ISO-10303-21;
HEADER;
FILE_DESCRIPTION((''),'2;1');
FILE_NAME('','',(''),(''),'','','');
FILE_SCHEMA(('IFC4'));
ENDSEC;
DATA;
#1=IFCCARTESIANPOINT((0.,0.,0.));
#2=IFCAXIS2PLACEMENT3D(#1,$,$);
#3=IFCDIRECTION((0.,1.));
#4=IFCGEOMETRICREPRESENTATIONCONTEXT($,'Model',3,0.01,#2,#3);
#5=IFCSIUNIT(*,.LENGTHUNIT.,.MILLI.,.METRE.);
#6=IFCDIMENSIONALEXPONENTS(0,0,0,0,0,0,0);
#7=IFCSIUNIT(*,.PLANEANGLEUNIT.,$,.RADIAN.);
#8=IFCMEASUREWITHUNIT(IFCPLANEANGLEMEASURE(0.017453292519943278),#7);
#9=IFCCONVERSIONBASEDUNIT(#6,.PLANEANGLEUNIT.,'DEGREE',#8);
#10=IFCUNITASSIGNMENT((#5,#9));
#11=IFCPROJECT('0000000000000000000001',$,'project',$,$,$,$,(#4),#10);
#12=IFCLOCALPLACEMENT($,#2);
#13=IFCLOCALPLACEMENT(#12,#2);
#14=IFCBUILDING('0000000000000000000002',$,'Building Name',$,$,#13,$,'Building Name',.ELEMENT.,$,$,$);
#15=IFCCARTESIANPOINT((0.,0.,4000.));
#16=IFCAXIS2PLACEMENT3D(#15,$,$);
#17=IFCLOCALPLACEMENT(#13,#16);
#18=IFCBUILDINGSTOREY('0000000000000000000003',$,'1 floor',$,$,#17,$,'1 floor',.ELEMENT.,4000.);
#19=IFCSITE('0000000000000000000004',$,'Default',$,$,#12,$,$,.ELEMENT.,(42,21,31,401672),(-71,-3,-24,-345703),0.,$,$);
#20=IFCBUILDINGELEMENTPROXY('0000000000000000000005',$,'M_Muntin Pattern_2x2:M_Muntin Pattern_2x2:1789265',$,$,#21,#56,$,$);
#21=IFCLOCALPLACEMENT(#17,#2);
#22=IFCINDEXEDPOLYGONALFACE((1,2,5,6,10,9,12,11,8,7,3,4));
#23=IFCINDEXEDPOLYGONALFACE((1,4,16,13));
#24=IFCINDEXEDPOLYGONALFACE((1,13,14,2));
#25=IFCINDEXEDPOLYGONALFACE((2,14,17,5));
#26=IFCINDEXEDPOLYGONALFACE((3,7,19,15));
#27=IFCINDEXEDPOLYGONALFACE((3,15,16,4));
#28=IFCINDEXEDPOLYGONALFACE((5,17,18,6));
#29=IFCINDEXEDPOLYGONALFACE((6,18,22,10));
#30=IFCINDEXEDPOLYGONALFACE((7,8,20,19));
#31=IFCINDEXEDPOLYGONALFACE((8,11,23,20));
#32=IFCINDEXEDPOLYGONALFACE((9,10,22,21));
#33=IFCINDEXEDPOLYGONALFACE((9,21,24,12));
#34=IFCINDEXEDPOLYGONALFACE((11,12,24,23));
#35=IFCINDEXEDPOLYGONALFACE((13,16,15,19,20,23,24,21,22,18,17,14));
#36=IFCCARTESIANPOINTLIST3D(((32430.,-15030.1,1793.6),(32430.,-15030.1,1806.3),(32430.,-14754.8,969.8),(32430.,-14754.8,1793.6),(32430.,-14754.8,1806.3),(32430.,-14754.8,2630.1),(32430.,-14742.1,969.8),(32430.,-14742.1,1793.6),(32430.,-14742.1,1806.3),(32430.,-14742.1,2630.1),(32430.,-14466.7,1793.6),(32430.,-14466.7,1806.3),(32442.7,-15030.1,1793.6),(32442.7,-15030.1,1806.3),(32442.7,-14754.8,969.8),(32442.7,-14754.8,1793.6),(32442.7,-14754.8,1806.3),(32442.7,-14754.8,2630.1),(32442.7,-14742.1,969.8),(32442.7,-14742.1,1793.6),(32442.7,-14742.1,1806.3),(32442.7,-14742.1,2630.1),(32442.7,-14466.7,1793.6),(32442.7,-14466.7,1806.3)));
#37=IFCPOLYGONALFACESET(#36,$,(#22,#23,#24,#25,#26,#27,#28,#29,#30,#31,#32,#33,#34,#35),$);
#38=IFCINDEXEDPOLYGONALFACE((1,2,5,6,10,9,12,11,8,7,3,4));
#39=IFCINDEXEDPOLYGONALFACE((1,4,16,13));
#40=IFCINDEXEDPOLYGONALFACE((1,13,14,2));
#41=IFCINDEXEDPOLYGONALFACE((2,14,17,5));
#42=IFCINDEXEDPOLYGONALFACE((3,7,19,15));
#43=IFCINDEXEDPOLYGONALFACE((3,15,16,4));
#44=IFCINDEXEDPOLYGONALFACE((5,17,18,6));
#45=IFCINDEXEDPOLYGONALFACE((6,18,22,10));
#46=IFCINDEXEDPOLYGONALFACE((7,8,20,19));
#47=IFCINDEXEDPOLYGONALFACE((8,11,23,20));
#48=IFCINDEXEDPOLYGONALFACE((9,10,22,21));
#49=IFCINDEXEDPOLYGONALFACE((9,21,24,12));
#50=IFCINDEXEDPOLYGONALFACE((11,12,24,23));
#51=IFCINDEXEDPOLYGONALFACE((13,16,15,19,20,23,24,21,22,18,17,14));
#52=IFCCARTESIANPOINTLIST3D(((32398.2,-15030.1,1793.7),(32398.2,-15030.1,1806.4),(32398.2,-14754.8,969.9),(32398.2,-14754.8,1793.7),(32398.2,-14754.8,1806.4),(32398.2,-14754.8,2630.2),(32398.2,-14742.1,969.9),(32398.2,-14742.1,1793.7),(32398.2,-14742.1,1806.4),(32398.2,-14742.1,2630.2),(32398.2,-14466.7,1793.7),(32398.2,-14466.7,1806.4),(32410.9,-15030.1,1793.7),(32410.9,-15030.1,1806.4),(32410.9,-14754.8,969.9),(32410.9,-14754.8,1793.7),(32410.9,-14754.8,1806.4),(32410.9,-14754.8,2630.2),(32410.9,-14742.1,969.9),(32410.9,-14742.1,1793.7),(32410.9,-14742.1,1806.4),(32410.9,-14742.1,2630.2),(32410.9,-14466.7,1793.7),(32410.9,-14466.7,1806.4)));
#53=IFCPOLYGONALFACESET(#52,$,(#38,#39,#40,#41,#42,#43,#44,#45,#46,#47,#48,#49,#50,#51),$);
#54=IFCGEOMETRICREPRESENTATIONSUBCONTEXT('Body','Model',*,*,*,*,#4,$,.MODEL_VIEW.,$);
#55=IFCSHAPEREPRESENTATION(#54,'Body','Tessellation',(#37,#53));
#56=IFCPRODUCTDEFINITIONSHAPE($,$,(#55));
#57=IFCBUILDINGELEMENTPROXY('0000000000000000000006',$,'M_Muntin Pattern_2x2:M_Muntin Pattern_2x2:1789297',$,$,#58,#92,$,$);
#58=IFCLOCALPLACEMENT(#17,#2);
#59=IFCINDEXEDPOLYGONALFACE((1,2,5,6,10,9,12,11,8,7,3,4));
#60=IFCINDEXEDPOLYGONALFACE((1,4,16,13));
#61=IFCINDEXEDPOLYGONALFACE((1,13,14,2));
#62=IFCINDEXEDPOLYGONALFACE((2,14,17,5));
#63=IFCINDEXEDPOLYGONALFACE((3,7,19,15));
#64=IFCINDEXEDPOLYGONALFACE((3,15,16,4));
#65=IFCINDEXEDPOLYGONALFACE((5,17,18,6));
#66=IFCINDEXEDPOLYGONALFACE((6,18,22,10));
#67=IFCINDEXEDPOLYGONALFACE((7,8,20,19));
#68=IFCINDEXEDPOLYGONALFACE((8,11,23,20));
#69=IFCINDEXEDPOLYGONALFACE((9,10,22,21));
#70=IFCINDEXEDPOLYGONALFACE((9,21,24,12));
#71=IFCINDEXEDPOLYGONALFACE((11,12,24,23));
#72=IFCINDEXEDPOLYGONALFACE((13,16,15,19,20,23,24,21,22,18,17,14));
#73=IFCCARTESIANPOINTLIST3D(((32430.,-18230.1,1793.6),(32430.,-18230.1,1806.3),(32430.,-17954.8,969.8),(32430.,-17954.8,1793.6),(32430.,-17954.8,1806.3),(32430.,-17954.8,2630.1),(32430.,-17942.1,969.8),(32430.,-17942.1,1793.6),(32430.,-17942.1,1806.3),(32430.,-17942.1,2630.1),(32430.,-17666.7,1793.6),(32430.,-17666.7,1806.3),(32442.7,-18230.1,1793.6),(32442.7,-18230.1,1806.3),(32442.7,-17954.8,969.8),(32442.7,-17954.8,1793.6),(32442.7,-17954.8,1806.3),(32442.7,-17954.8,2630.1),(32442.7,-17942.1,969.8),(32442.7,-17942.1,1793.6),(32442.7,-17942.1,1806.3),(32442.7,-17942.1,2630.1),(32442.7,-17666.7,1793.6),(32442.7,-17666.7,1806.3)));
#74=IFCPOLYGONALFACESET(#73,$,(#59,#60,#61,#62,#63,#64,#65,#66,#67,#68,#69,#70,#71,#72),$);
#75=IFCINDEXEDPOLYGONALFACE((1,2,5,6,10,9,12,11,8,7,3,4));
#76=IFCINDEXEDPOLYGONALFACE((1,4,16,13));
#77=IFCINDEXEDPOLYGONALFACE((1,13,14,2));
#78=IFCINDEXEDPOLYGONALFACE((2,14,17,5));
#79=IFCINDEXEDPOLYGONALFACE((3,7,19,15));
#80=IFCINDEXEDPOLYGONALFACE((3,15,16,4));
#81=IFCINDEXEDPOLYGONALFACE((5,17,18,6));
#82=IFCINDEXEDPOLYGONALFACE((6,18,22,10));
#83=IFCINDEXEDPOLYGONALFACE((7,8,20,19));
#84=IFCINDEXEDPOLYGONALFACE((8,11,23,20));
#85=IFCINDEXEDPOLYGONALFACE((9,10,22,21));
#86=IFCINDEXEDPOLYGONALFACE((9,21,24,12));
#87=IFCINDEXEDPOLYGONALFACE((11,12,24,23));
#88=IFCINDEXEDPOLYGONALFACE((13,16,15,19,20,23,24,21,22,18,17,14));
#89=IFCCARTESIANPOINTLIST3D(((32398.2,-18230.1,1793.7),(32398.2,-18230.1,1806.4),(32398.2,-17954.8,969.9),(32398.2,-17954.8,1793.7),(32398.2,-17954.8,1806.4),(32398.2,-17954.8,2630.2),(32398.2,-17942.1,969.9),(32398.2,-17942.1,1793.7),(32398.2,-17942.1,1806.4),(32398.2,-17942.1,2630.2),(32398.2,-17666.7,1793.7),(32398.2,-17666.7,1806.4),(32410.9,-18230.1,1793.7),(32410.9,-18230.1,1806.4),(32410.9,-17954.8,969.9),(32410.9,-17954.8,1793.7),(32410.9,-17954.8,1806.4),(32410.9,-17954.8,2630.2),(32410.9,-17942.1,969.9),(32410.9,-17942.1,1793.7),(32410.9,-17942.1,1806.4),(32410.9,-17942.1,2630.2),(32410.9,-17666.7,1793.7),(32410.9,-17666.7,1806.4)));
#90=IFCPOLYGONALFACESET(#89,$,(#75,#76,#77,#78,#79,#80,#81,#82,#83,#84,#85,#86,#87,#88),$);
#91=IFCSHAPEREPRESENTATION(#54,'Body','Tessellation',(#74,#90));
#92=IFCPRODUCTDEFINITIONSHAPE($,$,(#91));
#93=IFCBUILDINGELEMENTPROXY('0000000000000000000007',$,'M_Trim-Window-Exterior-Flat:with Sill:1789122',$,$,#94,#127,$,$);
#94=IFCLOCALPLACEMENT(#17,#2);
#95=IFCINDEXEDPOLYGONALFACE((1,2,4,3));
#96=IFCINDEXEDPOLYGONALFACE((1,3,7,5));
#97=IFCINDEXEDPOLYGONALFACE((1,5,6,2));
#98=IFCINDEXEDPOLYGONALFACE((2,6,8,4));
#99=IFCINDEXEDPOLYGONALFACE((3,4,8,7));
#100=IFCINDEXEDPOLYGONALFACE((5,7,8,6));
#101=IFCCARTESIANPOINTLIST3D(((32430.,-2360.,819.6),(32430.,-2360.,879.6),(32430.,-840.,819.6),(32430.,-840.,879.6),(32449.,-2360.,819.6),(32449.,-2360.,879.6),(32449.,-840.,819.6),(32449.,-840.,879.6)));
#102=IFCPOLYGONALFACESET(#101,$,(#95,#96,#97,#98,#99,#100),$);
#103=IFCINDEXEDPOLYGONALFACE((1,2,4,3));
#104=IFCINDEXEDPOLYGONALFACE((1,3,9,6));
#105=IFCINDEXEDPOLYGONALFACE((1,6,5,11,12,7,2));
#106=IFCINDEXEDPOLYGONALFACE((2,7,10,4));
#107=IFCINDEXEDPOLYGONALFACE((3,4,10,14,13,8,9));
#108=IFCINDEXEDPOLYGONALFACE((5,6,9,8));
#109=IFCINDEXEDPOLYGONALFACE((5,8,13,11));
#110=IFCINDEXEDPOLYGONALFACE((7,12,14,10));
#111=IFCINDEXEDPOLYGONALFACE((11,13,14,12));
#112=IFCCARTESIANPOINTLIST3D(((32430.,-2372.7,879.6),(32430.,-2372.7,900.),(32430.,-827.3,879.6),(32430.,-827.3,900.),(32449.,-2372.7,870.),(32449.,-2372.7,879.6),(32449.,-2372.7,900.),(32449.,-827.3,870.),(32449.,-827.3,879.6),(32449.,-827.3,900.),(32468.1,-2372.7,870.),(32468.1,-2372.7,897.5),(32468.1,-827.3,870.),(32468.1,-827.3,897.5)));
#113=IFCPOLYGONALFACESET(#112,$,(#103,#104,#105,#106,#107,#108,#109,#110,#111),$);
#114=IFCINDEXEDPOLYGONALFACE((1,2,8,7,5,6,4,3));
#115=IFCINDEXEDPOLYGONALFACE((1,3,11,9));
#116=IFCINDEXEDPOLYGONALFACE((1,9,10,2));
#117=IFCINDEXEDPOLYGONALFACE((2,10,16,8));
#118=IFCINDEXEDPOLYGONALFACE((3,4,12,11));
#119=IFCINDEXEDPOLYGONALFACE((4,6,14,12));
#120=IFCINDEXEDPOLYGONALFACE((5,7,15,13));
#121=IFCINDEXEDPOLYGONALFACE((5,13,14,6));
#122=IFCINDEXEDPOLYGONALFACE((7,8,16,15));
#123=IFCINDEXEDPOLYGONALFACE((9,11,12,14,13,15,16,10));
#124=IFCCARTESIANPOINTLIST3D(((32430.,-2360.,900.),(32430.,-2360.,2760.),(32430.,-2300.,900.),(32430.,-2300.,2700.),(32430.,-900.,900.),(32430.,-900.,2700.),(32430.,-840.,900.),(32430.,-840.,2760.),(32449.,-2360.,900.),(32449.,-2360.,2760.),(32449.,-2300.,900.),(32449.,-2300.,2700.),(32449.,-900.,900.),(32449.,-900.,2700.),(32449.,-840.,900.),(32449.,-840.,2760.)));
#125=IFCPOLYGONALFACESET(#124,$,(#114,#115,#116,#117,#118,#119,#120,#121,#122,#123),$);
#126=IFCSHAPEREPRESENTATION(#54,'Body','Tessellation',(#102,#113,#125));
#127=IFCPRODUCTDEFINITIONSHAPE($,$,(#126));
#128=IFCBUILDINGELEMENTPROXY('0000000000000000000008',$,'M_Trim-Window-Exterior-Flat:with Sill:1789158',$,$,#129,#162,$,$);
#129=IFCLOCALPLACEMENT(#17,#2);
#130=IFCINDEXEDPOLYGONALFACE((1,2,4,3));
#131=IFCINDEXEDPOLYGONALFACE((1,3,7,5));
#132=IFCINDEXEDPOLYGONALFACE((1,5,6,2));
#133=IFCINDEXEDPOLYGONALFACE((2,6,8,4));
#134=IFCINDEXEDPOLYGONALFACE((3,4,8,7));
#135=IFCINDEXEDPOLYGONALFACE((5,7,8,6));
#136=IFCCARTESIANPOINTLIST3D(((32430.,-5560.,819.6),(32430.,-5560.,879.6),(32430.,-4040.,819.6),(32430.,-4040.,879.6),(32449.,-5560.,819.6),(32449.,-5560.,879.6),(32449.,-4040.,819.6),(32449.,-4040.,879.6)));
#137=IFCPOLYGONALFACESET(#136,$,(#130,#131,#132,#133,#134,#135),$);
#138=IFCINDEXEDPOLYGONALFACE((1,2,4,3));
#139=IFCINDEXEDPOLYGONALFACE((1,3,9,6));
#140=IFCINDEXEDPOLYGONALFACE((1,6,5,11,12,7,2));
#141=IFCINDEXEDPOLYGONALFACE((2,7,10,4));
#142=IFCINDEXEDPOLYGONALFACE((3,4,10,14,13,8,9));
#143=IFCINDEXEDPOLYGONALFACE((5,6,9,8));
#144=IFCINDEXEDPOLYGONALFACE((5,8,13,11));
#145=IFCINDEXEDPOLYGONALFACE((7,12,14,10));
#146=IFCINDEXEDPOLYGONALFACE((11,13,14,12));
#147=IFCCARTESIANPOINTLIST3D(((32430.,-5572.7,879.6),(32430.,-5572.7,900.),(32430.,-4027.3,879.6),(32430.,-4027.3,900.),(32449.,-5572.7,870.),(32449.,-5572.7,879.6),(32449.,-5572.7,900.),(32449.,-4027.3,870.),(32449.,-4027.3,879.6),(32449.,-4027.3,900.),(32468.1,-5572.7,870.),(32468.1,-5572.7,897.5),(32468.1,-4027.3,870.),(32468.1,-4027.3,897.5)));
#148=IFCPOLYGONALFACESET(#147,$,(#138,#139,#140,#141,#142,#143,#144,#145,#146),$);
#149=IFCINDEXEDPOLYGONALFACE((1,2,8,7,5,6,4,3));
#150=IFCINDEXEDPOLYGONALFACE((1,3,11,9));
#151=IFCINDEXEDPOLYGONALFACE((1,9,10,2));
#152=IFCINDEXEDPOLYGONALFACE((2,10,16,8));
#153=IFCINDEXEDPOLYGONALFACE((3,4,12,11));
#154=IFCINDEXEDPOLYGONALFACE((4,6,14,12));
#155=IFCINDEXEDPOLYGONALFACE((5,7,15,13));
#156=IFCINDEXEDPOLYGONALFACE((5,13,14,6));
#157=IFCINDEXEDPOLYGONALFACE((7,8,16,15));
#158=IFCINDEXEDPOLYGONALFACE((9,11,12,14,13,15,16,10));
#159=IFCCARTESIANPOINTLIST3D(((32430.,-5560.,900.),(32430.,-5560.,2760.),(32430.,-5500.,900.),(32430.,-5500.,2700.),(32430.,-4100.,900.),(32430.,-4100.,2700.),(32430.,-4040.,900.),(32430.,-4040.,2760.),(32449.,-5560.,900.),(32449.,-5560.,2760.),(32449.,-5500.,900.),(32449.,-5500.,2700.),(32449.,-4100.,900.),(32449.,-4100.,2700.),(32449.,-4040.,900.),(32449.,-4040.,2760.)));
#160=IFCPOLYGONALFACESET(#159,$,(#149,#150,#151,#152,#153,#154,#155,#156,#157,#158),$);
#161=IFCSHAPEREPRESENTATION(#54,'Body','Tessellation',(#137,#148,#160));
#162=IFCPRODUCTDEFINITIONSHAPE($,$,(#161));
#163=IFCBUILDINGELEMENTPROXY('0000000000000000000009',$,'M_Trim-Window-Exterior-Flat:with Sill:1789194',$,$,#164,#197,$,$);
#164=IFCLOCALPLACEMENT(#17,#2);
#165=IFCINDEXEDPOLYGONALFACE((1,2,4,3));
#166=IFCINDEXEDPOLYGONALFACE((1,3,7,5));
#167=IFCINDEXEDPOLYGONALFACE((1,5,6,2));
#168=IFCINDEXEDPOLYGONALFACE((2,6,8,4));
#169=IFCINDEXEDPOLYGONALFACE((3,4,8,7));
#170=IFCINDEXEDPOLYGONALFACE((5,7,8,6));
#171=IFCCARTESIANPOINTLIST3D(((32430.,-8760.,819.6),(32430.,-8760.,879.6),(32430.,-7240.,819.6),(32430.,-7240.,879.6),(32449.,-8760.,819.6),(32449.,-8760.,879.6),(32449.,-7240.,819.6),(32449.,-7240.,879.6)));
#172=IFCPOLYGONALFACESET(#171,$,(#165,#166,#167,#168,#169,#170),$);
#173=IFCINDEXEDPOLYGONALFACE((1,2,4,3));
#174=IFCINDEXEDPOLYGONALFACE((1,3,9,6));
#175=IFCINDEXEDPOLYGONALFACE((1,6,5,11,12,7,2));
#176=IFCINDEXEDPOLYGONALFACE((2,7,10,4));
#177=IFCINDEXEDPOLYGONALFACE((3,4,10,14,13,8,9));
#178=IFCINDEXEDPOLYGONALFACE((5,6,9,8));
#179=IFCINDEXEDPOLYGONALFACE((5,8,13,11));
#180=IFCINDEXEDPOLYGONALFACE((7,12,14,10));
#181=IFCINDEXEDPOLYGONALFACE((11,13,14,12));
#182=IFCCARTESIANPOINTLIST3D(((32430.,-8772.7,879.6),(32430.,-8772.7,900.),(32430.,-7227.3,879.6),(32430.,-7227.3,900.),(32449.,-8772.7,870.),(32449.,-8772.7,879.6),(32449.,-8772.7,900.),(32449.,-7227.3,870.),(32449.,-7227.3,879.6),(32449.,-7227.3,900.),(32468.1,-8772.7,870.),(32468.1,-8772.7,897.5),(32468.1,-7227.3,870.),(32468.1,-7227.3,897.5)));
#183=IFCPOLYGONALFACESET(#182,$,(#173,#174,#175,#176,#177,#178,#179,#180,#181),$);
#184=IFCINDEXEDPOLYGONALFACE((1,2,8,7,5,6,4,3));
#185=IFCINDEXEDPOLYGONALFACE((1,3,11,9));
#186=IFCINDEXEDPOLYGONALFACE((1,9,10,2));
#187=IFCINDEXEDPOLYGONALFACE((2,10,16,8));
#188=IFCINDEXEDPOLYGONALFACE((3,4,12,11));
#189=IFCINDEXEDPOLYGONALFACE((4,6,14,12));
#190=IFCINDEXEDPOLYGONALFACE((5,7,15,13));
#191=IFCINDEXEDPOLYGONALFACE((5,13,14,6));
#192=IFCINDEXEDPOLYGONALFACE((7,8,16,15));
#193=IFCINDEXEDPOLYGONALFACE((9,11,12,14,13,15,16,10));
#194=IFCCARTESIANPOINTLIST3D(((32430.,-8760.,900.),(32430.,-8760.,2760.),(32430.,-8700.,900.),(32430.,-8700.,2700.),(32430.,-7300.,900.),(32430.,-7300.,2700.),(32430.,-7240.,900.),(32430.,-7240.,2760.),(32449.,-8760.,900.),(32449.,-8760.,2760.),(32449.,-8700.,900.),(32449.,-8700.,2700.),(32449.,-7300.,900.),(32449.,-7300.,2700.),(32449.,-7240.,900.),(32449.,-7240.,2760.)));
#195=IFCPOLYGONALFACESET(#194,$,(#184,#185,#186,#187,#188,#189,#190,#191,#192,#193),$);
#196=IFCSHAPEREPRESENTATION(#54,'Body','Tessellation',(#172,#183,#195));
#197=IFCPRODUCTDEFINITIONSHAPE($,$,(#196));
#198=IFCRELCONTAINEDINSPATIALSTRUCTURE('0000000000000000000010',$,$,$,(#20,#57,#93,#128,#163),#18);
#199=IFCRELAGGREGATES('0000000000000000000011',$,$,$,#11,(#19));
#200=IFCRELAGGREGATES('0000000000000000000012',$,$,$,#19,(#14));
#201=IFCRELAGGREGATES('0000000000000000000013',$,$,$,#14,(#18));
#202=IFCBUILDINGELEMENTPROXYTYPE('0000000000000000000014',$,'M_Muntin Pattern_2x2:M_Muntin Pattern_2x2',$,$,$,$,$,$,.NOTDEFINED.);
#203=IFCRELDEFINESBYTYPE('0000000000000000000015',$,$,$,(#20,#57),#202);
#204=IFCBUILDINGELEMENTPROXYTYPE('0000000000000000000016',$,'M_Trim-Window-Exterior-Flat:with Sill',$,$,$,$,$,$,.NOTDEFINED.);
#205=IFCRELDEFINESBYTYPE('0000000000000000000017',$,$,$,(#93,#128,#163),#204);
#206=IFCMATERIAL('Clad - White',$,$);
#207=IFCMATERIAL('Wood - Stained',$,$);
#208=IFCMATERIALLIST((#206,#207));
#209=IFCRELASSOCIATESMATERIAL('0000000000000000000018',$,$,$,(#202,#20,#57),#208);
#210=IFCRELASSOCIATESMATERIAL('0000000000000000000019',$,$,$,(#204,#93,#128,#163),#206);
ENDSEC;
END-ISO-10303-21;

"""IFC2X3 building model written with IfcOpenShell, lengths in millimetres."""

from ifc_helpers import new_model, entity, si_unit, converted_unit, direction, frame, frame_2d, origin, place, context, subcontext, project, spatial, polyline, rectangle, outline, extrude, source, transform, mapped, material, material_list, type_object, type_shapes, element, save


model = new_model("IFC2X3")

# Units and contexts
model_context = context("Model", 3, precision=0.01, world=origin(), true_north=direction((0.0, 1.0)))
body_context = subcontext(model_context, "Body", "Model", "MODEL_VIEW")
ifc_project = project(units=[si_unit("LENGTHUNIT", "METRE", prefix="MILLI"), converted_unit("PLANEANGLEUNIT", "DEGREE", entity("IfcPlaneAngleMeasure", 0.017453292519943278), si_unit("PLANEANGLEUNIT", "RADIAN"), dimensions=[0, 0, 0, 0, 0, 0, 0])], contexts=[model_context])

# Site, building, storey
site_placement = place(None, origin())
site = spatial("IfcSite", under=ifc_project, at=site_placement, Name="Default", CompositionType="ELEMENT", RefLatitude=(42, 21, 31, 401672), RefLongitude=(-71, -3, -24, -345703), RefElevation=0.0)
building_placement = place(site_placement, origin())
building = spatial("IfcBuilding", under=site, at=building_placement, Name="Building Name", LongName="Building Name", CompositionType="ELEMENT")
storey_placement = place(building_placement, frame((0.0, 0.0, 4000.0)))
storey = spatial("IfcBuildingStorey", under=building, at=storey_placement, Name="1 floor", LongName="1 floor", CompositionType="ELEMENT", Elevation=4000.0)

# Building element proxies
ifc_material_1 = material(Name="Clad - White")
ifc_material_2 = material(Name="Wood - Stained")
ifc_material_list = material_list([ifc_material_1, ifc_material_2])
building_element_proxy_type_1 = type_object("IfcBuildingElementProxyType", Name="M_Muntin Pattern_2x2:M_Muntin Pattern_2x2", PredefinedType="NOTDEFINED", material=ifc_material_list)
shared_shape_1 = source(origin(), body_context, "Body", "SweptSolid", [
    extrude(outline(polyline([(6.4, -6.4), (830.1, -6.4), (830.1, 6.3), (6.4, 6.3), (6.4, 281.7), (-6.3, 281.7), (-6.3, 6.3), (-830.2, 6.3), (-830.2, -6.4), (-6.3, -6.4), (-6.3, -281.7), (6.4, -281.7), (6.4, -6.4)])), frame((0.0, -22.2, 830.1), z_axis=(0.0, 1.0, 0.0), x_axis=(0.0, 0.0, 1.0)), (0.0, 0.0, 1.0), 12.7),
    extrude(outline(polyline([(6.4, -6.4), (830.2, -6.4), (830.2, 6.3), (6.4, 6.3), (6.4, 281.7), (-6.3, 281.7), (-6.3, 6.3), (-830.2, 6.3), (-830.2, -6.4), (-6.3, -6.4), (-6.3, -281.7), (6.4, -281.7), (6.4, -6.4)])), frame((0.0, 9.5, 830.2), z_axis=(0.0, 1.0, 0.0), x_axis=(0.0, 0.0, 1.0)), (0.0, 0.0, 1.0), 12.7),
])
type_shapes(building_element_proxy_type_1, [shared_shape_1])
for number, where, z_axis, x_axis, name in (
    (1, (32420.5, -14748.4, 969.9), (0.0, 0.0, 1.0), (0.0, 1.0, 0.0), "M_Muntin Pattern_2x2:M_Muntin Pattern_2x2:1789265"),
    (2, (32420.5, -17948.4, 969.9), (0.0, 0.0, 1.0), (0.0, 1.0, 0.0), "M_Muntin Pattern_2x2:M_Muntin Pattern_2x2:1789297"),
):
    element("IfcBuildingElementProxy", number, at=place(storey_placement, frame(where, z_axis=z_axis, x_axis=x_axis)), inside=storey, type_object=building_element_proxy_type_1, material=ifc_material_list, Name=name, context=body_context, shape_type="MappedRepresentation", body=[
        mapped(shared_shape_1, transform((0.0, 0.0, 0.0), scale=1.0)),
    ])
building_element_proxy_type_2 = type_object("IfcBuildingElementProxyType", Name="M_Trim-Window-Exterior-Flat:with Sill", PredefinedType="NOTDEFINED", material=ifc_material_1)
shared_shape_2 = source(origin(), body_context, "Body", "SweptSolid", [
    extrude(rectangle(XDim=1520.0, YDim=60.0, at=frame_2d((0.0, 0.0), x_axis=(1.0, 0.0))), frame((0.0, -1850.4, 0.0), z_axis=(0.0, 0.0, 1.0), x_axis=(-1.0, 0.0, 0.0)), (0.0, 0.0, 1.0), 19.0),
    extrude(outline(polyline([(-19.0, -15.2), (0.0, -15.2), (0.0, -5.7), (19.0, -5.7), (19.0, 14.8), (0.0, 14.8), (-19.0, 12.3), (-19.0, -15.2)])), frame((-772.7, -1814.8, 19.0), z_axis=(1.0, 0.0, 0.0), x_axis=(0.0, 0.0, -1.0)), (0.0, 0.0, 1.0), 1545.4),
    extrude(outline(polyline([(-945.0, -760.0), (915.0, -760.0), (915.0, -700.0), (-885.0, -700.0), (-885.0, 700.0), (915.0, 700.0), (915.0, 760.0), (-945.0, 760.0), (-945.0, -760.0)])), frame((0.0, -885.0, 0.0), z_axis=(0.0, 0.0, 1.0), x_axis=(0.0, -1.0, 0.0)), (0.0, 0.0, 1.0), 19.0),
])
type_shapes(building_element_proxy_type_2, [shared_shape_2])
for number, where, z_axis, x_axis, name in (
    (3, (32430.0, -1600.0, 2700.0), (1.0, 0.0, 0.0), (0.0, 1.0, 0.0), "M_Trim-Window-Exterior-Flat:with Sill:1789122"),
    (4, (32430.0, -4800.0, 2700.0), (1.0, 0.0, 0.0), (0.0, 1.0, 0.0), "M_Trim-Window-Exterior-Flat:with Sill:1789158"),
    (5, (32430.0, -8000.0, 2700.0), (1.0, 0.0, 0.0), (0.0, 1.0, 0.0), "M_Trim-Window-Exterior-Flat:with Sill:1789194"),
):
    element("IfcBuildingElementProxy", number, at=place(storey_placement, frame(where, z_axis=z_axis, x_axis=x_axis)), inside=storey, type_object=building_element_proxy_type_2, material=ifc_material_1, Name=name, context=body_context, shape_type="MappedRepresentation", body=[
        mapped(shared_shape_2, transform((0.0, 0.0, 0.0), scale=1.0)),
    ])

save(model, "model.ifc")
